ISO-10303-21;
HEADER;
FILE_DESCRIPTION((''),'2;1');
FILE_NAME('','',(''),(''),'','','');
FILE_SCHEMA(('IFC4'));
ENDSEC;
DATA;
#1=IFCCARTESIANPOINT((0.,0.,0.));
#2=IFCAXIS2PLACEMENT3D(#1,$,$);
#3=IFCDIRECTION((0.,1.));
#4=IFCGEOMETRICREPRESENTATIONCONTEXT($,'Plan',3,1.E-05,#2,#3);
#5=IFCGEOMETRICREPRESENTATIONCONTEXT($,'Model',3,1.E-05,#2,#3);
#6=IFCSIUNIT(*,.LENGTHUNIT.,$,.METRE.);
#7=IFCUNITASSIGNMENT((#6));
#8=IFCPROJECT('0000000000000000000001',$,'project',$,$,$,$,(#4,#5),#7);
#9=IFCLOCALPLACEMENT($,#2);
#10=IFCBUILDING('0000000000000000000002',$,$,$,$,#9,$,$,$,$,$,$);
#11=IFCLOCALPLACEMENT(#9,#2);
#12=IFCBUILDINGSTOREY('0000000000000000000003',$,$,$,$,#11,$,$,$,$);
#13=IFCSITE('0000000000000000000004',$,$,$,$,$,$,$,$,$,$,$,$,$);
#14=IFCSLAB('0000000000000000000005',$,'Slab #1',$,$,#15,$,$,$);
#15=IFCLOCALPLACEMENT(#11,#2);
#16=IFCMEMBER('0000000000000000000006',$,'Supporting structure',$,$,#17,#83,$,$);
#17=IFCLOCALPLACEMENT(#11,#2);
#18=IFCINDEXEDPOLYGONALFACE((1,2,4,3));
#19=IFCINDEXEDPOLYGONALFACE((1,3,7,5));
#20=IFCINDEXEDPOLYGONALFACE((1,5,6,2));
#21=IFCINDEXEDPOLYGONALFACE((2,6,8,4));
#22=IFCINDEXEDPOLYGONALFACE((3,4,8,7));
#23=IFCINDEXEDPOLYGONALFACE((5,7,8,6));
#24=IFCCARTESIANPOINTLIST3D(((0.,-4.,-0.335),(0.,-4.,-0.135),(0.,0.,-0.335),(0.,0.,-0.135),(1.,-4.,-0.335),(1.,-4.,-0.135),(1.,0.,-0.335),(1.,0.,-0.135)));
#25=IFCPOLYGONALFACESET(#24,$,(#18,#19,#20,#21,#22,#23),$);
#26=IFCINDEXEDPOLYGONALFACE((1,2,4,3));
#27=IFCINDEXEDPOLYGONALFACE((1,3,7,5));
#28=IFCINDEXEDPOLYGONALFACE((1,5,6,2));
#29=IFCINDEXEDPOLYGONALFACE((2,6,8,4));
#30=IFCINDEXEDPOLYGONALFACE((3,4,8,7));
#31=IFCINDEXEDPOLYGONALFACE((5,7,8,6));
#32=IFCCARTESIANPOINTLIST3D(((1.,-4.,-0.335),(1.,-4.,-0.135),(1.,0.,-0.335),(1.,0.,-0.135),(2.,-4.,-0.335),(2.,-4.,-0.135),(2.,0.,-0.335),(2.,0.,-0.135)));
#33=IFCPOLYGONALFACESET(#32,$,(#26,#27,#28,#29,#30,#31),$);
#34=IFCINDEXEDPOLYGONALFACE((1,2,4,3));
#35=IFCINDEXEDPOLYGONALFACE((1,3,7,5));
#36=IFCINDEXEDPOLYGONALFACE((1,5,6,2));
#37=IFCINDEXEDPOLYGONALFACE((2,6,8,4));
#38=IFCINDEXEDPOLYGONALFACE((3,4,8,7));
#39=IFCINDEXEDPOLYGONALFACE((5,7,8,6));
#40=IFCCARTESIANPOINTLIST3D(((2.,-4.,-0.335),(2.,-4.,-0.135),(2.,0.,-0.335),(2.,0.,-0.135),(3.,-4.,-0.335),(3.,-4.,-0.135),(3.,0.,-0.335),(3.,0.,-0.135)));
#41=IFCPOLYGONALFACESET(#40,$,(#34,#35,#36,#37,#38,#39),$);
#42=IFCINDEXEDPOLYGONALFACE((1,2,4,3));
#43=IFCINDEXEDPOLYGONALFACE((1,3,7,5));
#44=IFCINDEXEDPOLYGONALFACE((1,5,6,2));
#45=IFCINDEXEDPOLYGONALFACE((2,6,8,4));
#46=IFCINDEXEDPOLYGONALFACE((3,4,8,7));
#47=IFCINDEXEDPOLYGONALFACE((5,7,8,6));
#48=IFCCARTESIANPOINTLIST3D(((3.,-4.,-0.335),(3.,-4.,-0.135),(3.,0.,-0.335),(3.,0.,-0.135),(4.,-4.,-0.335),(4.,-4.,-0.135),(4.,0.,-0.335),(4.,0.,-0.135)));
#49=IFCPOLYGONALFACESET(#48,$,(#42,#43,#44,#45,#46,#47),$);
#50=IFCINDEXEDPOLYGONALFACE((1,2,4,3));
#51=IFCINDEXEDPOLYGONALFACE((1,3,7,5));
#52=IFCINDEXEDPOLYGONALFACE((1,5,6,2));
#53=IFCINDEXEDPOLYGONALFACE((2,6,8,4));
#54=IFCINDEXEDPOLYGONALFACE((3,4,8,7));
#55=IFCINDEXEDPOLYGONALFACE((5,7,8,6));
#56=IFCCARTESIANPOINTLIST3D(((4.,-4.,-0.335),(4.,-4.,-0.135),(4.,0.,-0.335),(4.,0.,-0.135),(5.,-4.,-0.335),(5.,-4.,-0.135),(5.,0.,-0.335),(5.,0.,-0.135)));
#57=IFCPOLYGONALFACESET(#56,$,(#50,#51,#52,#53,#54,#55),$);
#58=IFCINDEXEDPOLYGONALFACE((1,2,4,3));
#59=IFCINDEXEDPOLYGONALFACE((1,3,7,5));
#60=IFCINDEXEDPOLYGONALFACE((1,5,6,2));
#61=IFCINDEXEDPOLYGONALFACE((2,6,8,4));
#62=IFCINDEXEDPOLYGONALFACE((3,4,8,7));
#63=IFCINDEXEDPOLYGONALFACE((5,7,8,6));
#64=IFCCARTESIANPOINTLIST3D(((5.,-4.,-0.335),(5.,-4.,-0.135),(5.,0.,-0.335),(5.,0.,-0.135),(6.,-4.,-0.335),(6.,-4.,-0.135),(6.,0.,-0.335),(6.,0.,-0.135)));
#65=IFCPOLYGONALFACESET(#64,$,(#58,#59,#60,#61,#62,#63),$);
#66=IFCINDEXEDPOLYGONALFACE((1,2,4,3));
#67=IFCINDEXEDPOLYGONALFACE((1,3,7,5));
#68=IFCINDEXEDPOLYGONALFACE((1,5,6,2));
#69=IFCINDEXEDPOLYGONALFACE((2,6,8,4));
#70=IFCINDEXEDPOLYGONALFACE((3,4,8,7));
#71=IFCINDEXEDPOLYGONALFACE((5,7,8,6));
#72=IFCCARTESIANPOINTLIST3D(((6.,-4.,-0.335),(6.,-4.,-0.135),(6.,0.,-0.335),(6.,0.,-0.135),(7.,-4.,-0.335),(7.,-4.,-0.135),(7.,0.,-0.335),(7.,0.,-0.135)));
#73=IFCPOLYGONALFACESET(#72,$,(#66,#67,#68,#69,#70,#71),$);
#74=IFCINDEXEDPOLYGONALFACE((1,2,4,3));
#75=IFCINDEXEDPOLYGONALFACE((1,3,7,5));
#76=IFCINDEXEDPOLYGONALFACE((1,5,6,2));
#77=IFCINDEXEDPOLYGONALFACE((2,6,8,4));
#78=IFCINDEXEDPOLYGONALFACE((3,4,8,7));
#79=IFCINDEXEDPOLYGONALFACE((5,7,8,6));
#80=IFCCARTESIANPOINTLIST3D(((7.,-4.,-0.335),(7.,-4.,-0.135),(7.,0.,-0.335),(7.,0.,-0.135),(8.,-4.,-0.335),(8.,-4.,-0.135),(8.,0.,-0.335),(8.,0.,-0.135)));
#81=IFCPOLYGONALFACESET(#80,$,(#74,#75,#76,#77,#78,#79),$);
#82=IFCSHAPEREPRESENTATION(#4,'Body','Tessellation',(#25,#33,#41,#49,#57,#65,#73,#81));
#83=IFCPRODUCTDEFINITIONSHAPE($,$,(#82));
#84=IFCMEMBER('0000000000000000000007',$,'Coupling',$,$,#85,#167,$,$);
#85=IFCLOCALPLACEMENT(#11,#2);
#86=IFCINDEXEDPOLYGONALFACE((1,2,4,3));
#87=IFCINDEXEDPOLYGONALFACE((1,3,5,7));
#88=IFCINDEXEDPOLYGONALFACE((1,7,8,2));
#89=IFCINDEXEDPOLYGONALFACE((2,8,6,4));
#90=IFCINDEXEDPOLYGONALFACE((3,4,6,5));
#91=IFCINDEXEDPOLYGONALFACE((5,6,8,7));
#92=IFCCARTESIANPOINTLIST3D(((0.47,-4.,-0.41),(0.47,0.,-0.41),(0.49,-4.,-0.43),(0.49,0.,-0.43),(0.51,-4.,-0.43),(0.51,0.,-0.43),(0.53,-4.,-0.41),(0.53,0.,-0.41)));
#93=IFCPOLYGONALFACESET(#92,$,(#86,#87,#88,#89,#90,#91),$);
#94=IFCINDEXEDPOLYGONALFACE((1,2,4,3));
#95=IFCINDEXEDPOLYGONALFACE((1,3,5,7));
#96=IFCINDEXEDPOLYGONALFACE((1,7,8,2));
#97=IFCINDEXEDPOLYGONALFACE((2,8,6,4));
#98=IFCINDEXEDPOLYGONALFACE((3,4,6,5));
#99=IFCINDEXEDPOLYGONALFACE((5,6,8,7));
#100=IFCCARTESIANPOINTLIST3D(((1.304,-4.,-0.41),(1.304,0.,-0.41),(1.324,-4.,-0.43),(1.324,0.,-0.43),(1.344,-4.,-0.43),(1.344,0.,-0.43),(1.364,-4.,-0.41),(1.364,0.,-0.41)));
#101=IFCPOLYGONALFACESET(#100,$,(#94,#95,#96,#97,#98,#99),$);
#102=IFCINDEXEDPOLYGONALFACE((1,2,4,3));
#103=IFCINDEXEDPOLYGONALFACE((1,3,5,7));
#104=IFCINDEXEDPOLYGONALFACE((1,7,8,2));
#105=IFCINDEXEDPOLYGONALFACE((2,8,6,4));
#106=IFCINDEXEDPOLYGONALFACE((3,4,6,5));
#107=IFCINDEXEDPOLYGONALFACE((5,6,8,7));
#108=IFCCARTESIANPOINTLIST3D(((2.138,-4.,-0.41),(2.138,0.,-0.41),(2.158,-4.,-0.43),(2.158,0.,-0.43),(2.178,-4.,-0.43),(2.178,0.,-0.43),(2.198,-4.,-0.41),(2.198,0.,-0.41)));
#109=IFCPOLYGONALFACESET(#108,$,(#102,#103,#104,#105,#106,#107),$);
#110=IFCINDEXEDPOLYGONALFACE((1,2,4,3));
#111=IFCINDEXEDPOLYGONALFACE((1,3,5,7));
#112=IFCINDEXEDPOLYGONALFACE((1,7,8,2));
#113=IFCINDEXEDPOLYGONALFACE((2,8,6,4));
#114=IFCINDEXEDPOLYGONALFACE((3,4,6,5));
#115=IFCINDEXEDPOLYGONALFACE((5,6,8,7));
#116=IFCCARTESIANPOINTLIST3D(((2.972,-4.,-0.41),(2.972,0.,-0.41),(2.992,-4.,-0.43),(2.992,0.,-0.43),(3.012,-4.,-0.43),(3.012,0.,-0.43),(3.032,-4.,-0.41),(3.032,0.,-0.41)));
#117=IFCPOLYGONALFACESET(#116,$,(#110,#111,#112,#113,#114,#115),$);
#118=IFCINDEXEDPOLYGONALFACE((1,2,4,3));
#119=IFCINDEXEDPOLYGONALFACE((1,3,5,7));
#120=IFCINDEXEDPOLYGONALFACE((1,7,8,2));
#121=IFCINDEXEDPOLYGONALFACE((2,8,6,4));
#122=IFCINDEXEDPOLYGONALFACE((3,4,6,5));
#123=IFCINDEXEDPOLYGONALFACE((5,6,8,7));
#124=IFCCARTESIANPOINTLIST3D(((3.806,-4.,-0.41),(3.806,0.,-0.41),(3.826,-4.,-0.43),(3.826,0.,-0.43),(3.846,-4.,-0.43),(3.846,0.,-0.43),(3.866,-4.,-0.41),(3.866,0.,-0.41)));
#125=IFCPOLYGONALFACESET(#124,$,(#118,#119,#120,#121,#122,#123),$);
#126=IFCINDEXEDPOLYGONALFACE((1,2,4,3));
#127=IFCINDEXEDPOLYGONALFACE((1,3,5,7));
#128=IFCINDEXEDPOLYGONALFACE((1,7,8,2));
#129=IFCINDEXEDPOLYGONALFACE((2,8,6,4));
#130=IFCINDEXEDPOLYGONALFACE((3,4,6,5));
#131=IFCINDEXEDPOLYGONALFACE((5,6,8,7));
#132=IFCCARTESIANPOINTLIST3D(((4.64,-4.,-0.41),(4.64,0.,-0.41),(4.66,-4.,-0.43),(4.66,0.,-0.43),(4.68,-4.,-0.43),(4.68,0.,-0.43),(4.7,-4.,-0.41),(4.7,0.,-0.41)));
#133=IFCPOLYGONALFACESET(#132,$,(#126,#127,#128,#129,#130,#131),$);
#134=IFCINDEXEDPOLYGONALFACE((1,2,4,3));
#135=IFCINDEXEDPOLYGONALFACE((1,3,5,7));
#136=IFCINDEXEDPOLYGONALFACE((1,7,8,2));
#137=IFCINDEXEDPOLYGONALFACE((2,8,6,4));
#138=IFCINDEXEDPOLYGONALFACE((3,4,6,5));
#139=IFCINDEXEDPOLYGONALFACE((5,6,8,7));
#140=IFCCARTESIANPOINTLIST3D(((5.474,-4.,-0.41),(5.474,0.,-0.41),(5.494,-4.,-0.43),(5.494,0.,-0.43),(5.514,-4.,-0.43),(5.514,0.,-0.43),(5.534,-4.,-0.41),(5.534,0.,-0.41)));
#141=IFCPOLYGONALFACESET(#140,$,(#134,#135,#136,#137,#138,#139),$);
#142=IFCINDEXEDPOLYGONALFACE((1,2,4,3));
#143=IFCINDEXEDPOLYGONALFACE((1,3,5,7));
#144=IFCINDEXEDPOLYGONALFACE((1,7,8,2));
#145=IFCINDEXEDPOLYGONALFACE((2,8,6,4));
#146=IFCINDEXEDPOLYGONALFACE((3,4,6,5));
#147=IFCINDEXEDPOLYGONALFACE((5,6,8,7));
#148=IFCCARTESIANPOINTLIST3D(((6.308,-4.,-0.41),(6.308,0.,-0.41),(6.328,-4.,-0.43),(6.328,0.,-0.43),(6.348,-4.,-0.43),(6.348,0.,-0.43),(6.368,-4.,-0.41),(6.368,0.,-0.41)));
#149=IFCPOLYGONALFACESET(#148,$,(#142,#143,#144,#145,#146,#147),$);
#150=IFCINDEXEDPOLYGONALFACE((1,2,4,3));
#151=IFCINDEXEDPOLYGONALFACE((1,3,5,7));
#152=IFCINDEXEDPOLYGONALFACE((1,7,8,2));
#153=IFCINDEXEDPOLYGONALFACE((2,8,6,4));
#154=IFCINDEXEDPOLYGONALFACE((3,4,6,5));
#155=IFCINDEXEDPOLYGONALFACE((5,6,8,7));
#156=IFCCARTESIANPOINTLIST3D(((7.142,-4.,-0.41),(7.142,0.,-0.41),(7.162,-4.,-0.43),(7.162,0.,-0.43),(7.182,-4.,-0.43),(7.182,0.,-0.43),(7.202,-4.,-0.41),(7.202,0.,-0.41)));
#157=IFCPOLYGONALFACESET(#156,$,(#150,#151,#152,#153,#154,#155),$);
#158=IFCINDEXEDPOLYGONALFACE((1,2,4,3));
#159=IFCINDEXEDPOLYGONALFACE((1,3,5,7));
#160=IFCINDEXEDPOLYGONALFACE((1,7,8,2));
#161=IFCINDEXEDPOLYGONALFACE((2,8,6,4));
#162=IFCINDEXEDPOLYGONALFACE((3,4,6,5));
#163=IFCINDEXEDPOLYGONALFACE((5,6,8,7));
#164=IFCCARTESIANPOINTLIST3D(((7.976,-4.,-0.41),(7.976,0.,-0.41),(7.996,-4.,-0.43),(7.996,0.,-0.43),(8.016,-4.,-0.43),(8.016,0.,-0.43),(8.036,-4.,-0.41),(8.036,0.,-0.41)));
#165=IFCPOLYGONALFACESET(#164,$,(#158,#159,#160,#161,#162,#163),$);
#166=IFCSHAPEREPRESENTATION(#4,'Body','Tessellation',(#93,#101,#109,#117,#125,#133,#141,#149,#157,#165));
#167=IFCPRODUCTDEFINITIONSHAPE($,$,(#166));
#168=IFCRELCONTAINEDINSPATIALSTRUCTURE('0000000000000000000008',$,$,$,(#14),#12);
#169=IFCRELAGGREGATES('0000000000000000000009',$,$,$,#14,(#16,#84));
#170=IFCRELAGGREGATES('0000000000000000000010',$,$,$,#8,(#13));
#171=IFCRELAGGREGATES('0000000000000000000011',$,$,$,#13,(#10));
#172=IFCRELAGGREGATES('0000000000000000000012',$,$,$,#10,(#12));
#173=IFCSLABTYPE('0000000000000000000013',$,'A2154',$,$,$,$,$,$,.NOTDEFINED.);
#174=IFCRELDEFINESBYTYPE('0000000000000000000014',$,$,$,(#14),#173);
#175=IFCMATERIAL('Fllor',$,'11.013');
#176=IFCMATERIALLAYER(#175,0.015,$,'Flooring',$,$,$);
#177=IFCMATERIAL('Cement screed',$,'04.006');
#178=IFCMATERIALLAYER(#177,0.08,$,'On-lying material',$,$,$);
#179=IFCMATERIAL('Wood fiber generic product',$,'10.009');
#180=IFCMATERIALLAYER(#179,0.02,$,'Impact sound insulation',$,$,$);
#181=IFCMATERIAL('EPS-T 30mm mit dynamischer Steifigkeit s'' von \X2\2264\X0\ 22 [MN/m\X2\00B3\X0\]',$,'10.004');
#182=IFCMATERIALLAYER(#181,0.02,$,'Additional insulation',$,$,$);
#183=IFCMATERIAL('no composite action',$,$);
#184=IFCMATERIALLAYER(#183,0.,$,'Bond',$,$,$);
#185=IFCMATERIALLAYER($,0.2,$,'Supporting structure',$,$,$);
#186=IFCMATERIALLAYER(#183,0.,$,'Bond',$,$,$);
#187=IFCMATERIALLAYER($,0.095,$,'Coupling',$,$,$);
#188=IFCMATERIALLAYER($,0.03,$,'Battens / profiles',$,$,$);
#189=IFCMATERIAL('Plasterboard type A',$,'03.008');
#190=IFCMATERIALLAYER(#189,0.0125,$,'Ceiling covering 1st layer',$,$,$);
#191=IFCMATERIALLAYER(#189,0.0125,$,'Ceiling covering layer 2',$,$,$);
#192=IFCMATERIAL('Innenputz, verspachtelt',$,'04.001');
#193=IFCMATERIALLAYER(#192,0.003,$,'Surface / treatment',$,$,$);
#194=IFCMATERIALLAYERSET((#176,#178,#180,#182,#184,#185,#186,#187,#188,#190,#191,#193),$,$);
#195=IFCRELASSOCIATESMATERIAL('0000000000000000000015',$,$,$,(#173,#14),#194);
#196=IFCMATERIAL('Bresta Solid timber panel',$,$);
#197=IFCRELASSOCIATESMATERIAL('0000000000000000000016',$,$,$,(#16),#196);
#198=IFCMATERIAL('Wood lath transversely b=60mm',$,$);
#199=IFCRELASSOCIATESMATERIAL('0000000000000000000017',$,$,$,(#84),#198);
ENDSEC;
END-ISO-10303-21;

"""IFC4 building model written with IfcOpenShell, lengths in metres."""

from ifc_helpers import new_model, si_unit, direction, frame, frame_2d, origin, place, context, project, spatial, polyline, rectangle, outline, extrude, material, layer, layer_set, type_object, element, aggregate, save


model = new_model("IFC4")

# Units and contexts
plan_context = context("Plan", 3, precision=1e-05, world=origin(), true_north=direction((0.0, 1.0)))
model_context = context("Model", 3, precision=1e-05, world=origin(), true_north=direction((0.0, 1.0)))
ifc_project = project(units=[si_unit("LENGTHUNIT", "METRE")], contexts=[plan_context, model_context])

# Site, building, storey
site = spatial("IfcSite", under=ifc_project)
building_placement = place(None, origin())
building = spatial("IfcBuilding", under=site, at=building_placement)
storey_placement = place(building_placement, origin())
storey = spatial("IfcBuildingStorey", under=building, at=storey_placement)

# Slab, members
ifc_material_1 = material(Name="Fllor", Category="11.013")
ifc_layer_1 = layer(ifc_material_1, 0.015, Name="Flooring")
ifc_material_2 = material(Name="Cement screed", Category="04.006")
ifc_layer_2 = layer(ifc_material_2, 0.08, Name="On-lying material")
ifc_material_3 = material(Name="Wood fiber generic product", Category="10.009")
ifc_layer_3 = layer(ifc_material_3, 0.02, Name="Impact sound insulation")
ifc_material_4 = material(Name="EPS-T 30mm mit dynamischer Steifigkeit s' von ≤ 22 [MN/m³]", Category="10.004")
ifc_layer_4 = layer(ifc_material_4, 0.02, Name="Additional insulation")
ifc_material_5 = material(Name="no composite action")
ifc_layer_5 = layer(ifc_material_5, 0.0, Name="Bond")
ifc_layer_6 = layer(None, 0.2, Name="Supporting structure")
ifc_layer_7 = layer(ifc_material_5, 0.0, Name="Bond")
ifc_layer_8 = layer(None, 0.095, Name="Coupling")
ifc_layer_9 = layer(None, 0.03, Name="Battens / profiles")
ifc_material_6 = material(Name="Plasterboard type A", Category="03.008")
ifc_layer_10 = layer(ifc_material_6, 0.0125, Name="Ceiling covering 1st layer")
ifc_layer_11 = layer(ifc_material_6, 0.0125, Name="Ceiling covering layer 2")
ifc_material_7 = material(Name="Innenputz, verspachtelt", Category="04.001")
ifc_layer_12 = layer(ifc_material_7, 0.003, Name="Surface / treatment")
ifc_layer_set = layer_set([ifc_layer_1, ifc_layer_2, ifc_layer_3, ifc_layer_4, ifc_layer_5, ifc_layer_6, ifc_layer_7, ifc_layer_8, ifc_layer_9, ifc_layer_10, ifc_layer_11, ifc_layer_12])
slab_type = type_object("IfcSlabType", Name="A2154", PredefinedType="NOTDEFINED", material=ifc_layer_set)
slab_placement = place(None, frame((0.0, 0.0, 0.0), z_axis=(0.0, 0.0, -1.0), x_axis=(1.0, 0.0, 0.0)))
slab = element("IfcSlab", 1, at=slab_placement, inside=storey, type_object=slab_type, material=ifc_layer_set, Name="Slab #1")
ifc_material_8 = material(Name="Bresta Solid timber panel")
member_1_placement = place(slab_placement, origin())
member_1 = element("IfcMember", 2, at=member_1_placement, material=ifc_material_8, Name="Supporting structure", context=plan_context, shape_type="SweptSolid", body=[
    extrude(rectangle(XDim=1.0, YDim=0.2, at=frame_2d((0.5, 0.1), x_axis=(1.0, 0.0))), frame((0.0, 4.0, 0.135), z_axis=(0.0, -1.0, 0.0), x_axis=(1.0, 0.0, 0.0)), (0.0, 0.0, 1.0), 4.0),
    extrude(rectangle(XDim=1.0, YDim=0.2, at=frame_2d((0.5, 0.1), x_axis=(1.0, 0.0))), frame((1.0, 4.0, 0.135), z_axis=(0.0, -1.0, 0.0), x_axis=(1.0, 0.0, 0.0)), (0.0, 0.0, 1.0), 4.0),
    extrude(rectangle(XDim=1.0, YDim=0.2, at=frame_2d((0.5, 0.1), x_axis=(1.0, 0.0))), frame((2.0, 4.0, 0.135), z_axis=(0.0, -1.0, 0.0), x_axis=(1.0, 0.0, 0.0)), (0.0, 0.0, 1.0), 4.0),
    extrude(rectangle(XDim=1.0, YDim=0.2, at=frame_2d((0.5, 0.1), x_axis=(1.0, 0.0))), frame((3.0, 4.0, 0.135), z_axis=(0.0, -1.0, 0.0), x_axis=(1.0, 0.0, 0.0)), (0.0, 0.0, 1.0), 4.0),
    extrude(rectangle(XDim=1.0, YDim=0.2, at=frame_2d((0.5, 0.1), x_axis=(1.0, 0.0))), frame((4.0, 4.0, 0.135), z_axis=(0.0, -1.0, 0.0), x_axis=(1.0, 0.0, 0.0)), (0.0, 0.0, 1.0), 4.0),
    extrude(rectangle(XDim=1.0, YDim=0.2, at=frame_2d((0.5, 0.1), x_axis=(1.0, 0.0))), frame((5.0, 4.0, 0.135), z_axis=(0.0, -1.0, 0.0), x_axis=(1.0, 0.0, 0.0)), (0.0, 0.0, 1.0), 4.0),
    extrude(rectangle(XDim=1.0, YDim=0.2, at=frame_2d((0.5, 0.1), x_axis=(1.0, 0.0))), frame((6.0, 4.0, 0.135), z_axis=(0.0, -1.0, 0.0), x_axis=(1.0, 0.0, 0.0)), (0.0, 0.0, 1.0), 4.0),
    extrude(rectangle(XDim=1.0, YDim=0.2, at=frame_2d((0.5, 0.1), x_axis=(1.0, 0.0))), frame((7.0, 4.0, 0.135), z_axis=(0.0, -1.0, 0.0), x_axis=(1.0, 0.0, 0.0)), (0.0, 0.0, 1.0), 4.0),
])
ifc_material_9 = material(Name="Wood lath transversely b=60mm")
member_2_placement = place(slab_placement, origin())
member_2 = element("IfcMember", 3, at=member_2_placement, material=ifc_material_9, Name="Coupling", context=plan_context, shape_type="SweptSolid", body=[
    extrude(outline(polyline([(0.0, 0.0), (0.06, 0.0), (0.04, 0.02), (0.02, 0.02), (0.0, 0.0)])), frame((0.47, 4.0, 0.41), z_axis=(0.0, -1.0, 0.0), x_axis=(1.0, 0.0, 0.0)), (0.0, 0.0, 1.0), 4.0),
    extrude(outline(polyline([(0.0, 0.0), (0.06, 0.0), (0.04, 0.02), (0.02, 0.02), (0.0, 0.0)])), frame((1.304, 4.0, 0.41), z_axis=(0.0, -1.0, 0.0), x_axis=(1.0, 0.0, 0.0)), (0.0, 0.0, 1.0), 4.0),
    extrude(outline(polyline([(0.0, 0.0), (0.06, 0.0), (0.04, 0.02), (0.02, 0.02), (0.0, 0.0)])), frame((2.138, 4.0, 0.41), z_axis=(0.0, -1.0, 0.0), x_axis=(1.0, 0.0, 0.0)), (0.0, 0.0, 1.0), 4.0),
    extrude(outline(polyline([(0.0, 0.0), (0.06, 0.0), (0.04, 0.02), (0.02, 0.02), (0.0, 0.0)])), frame((2.972, 4.0, 0.41), z_axis=(0.0, -1.0, 0.0), x_axis=(1.0, 0.0, 0.0)), (0.0, 0.0, 1.0), 4.0),
    extrude(outline(polyline([(0.0, 0.0), (0.06, 0.0), (0.04, 0.02), (0.02, 0.02), (0.0, 0.0)])), frame((3.806, 4.0, 0.41), z_axis=(0.0, -1.0, 0.0), x_axis=(1.0, 0.0, 0.0)), (0.0, 0.0, 1.0), 4.0),
    extrude(outline(polyline([(0.0, 0.0), (0.06, 0.0), (0.04, 0.02), (0.02, 0.02), (0.0, 0.0)])), frame((4.64, 4.0, 0.41), z_axis=(0.0, -1.0, 0.0), x_axis=(1.0, 0.0, 0.0)), (0.0, 0.0, 1.0), 4.0),
    extrude(outline(polyline([(0.0, 0.0), (0.06, 0.0), (0.04, 0.02), (0.02, 0.02), (0.0, 0.0)])), frame((5.474, 4.0, 0.41), z_axis=(0.0, -1.0, 0.0), x_axis=(1.0, 0.0, 0.0)), (0.0, 0.0, 1.0), 4.0),
    extrude(outline(polyline([(0.0, 0.0), (0.06, 0.0), (0.04, 0.02), (0.02, 0.02), (0.0, 0.0)])), frame((6.308, 4.0, 0.41), z_axis=(0.0, -1.0, 0.0), x_axis=(1.0, 0.0, 0.0)), (0.0, 0.0, 1.0), 4.0),
    extrude(outline(polyline([(0.0, 0.0), (0.06, 0.0), (0.04, 0.02), (0.02, 0.02), (0.0, 0.0)])), frame((7.142, 4.0, 0.41), z_axis=(0.0, -1.0, 0.0), x_axis=(1.0, 0.0, 0.0)), (0.0, 0.0, 1.0), 4.0),
    extrude(outline(polyline([(0.0, 0.0), (0.06, 0.0), (0.04, 0.02), (0.02, 0.02), (0.0, 0.0)])), frame((7.976, 4.0, 0.41), z_axis=(0.0, -1.0, 0.0), x_axis=(1.0, 0.0, 0.0)), (0.0, 0.0, 1.0), 4.0),
])
aggregate(slab, [member_1, member_2])

save(model, "model.ifc")
